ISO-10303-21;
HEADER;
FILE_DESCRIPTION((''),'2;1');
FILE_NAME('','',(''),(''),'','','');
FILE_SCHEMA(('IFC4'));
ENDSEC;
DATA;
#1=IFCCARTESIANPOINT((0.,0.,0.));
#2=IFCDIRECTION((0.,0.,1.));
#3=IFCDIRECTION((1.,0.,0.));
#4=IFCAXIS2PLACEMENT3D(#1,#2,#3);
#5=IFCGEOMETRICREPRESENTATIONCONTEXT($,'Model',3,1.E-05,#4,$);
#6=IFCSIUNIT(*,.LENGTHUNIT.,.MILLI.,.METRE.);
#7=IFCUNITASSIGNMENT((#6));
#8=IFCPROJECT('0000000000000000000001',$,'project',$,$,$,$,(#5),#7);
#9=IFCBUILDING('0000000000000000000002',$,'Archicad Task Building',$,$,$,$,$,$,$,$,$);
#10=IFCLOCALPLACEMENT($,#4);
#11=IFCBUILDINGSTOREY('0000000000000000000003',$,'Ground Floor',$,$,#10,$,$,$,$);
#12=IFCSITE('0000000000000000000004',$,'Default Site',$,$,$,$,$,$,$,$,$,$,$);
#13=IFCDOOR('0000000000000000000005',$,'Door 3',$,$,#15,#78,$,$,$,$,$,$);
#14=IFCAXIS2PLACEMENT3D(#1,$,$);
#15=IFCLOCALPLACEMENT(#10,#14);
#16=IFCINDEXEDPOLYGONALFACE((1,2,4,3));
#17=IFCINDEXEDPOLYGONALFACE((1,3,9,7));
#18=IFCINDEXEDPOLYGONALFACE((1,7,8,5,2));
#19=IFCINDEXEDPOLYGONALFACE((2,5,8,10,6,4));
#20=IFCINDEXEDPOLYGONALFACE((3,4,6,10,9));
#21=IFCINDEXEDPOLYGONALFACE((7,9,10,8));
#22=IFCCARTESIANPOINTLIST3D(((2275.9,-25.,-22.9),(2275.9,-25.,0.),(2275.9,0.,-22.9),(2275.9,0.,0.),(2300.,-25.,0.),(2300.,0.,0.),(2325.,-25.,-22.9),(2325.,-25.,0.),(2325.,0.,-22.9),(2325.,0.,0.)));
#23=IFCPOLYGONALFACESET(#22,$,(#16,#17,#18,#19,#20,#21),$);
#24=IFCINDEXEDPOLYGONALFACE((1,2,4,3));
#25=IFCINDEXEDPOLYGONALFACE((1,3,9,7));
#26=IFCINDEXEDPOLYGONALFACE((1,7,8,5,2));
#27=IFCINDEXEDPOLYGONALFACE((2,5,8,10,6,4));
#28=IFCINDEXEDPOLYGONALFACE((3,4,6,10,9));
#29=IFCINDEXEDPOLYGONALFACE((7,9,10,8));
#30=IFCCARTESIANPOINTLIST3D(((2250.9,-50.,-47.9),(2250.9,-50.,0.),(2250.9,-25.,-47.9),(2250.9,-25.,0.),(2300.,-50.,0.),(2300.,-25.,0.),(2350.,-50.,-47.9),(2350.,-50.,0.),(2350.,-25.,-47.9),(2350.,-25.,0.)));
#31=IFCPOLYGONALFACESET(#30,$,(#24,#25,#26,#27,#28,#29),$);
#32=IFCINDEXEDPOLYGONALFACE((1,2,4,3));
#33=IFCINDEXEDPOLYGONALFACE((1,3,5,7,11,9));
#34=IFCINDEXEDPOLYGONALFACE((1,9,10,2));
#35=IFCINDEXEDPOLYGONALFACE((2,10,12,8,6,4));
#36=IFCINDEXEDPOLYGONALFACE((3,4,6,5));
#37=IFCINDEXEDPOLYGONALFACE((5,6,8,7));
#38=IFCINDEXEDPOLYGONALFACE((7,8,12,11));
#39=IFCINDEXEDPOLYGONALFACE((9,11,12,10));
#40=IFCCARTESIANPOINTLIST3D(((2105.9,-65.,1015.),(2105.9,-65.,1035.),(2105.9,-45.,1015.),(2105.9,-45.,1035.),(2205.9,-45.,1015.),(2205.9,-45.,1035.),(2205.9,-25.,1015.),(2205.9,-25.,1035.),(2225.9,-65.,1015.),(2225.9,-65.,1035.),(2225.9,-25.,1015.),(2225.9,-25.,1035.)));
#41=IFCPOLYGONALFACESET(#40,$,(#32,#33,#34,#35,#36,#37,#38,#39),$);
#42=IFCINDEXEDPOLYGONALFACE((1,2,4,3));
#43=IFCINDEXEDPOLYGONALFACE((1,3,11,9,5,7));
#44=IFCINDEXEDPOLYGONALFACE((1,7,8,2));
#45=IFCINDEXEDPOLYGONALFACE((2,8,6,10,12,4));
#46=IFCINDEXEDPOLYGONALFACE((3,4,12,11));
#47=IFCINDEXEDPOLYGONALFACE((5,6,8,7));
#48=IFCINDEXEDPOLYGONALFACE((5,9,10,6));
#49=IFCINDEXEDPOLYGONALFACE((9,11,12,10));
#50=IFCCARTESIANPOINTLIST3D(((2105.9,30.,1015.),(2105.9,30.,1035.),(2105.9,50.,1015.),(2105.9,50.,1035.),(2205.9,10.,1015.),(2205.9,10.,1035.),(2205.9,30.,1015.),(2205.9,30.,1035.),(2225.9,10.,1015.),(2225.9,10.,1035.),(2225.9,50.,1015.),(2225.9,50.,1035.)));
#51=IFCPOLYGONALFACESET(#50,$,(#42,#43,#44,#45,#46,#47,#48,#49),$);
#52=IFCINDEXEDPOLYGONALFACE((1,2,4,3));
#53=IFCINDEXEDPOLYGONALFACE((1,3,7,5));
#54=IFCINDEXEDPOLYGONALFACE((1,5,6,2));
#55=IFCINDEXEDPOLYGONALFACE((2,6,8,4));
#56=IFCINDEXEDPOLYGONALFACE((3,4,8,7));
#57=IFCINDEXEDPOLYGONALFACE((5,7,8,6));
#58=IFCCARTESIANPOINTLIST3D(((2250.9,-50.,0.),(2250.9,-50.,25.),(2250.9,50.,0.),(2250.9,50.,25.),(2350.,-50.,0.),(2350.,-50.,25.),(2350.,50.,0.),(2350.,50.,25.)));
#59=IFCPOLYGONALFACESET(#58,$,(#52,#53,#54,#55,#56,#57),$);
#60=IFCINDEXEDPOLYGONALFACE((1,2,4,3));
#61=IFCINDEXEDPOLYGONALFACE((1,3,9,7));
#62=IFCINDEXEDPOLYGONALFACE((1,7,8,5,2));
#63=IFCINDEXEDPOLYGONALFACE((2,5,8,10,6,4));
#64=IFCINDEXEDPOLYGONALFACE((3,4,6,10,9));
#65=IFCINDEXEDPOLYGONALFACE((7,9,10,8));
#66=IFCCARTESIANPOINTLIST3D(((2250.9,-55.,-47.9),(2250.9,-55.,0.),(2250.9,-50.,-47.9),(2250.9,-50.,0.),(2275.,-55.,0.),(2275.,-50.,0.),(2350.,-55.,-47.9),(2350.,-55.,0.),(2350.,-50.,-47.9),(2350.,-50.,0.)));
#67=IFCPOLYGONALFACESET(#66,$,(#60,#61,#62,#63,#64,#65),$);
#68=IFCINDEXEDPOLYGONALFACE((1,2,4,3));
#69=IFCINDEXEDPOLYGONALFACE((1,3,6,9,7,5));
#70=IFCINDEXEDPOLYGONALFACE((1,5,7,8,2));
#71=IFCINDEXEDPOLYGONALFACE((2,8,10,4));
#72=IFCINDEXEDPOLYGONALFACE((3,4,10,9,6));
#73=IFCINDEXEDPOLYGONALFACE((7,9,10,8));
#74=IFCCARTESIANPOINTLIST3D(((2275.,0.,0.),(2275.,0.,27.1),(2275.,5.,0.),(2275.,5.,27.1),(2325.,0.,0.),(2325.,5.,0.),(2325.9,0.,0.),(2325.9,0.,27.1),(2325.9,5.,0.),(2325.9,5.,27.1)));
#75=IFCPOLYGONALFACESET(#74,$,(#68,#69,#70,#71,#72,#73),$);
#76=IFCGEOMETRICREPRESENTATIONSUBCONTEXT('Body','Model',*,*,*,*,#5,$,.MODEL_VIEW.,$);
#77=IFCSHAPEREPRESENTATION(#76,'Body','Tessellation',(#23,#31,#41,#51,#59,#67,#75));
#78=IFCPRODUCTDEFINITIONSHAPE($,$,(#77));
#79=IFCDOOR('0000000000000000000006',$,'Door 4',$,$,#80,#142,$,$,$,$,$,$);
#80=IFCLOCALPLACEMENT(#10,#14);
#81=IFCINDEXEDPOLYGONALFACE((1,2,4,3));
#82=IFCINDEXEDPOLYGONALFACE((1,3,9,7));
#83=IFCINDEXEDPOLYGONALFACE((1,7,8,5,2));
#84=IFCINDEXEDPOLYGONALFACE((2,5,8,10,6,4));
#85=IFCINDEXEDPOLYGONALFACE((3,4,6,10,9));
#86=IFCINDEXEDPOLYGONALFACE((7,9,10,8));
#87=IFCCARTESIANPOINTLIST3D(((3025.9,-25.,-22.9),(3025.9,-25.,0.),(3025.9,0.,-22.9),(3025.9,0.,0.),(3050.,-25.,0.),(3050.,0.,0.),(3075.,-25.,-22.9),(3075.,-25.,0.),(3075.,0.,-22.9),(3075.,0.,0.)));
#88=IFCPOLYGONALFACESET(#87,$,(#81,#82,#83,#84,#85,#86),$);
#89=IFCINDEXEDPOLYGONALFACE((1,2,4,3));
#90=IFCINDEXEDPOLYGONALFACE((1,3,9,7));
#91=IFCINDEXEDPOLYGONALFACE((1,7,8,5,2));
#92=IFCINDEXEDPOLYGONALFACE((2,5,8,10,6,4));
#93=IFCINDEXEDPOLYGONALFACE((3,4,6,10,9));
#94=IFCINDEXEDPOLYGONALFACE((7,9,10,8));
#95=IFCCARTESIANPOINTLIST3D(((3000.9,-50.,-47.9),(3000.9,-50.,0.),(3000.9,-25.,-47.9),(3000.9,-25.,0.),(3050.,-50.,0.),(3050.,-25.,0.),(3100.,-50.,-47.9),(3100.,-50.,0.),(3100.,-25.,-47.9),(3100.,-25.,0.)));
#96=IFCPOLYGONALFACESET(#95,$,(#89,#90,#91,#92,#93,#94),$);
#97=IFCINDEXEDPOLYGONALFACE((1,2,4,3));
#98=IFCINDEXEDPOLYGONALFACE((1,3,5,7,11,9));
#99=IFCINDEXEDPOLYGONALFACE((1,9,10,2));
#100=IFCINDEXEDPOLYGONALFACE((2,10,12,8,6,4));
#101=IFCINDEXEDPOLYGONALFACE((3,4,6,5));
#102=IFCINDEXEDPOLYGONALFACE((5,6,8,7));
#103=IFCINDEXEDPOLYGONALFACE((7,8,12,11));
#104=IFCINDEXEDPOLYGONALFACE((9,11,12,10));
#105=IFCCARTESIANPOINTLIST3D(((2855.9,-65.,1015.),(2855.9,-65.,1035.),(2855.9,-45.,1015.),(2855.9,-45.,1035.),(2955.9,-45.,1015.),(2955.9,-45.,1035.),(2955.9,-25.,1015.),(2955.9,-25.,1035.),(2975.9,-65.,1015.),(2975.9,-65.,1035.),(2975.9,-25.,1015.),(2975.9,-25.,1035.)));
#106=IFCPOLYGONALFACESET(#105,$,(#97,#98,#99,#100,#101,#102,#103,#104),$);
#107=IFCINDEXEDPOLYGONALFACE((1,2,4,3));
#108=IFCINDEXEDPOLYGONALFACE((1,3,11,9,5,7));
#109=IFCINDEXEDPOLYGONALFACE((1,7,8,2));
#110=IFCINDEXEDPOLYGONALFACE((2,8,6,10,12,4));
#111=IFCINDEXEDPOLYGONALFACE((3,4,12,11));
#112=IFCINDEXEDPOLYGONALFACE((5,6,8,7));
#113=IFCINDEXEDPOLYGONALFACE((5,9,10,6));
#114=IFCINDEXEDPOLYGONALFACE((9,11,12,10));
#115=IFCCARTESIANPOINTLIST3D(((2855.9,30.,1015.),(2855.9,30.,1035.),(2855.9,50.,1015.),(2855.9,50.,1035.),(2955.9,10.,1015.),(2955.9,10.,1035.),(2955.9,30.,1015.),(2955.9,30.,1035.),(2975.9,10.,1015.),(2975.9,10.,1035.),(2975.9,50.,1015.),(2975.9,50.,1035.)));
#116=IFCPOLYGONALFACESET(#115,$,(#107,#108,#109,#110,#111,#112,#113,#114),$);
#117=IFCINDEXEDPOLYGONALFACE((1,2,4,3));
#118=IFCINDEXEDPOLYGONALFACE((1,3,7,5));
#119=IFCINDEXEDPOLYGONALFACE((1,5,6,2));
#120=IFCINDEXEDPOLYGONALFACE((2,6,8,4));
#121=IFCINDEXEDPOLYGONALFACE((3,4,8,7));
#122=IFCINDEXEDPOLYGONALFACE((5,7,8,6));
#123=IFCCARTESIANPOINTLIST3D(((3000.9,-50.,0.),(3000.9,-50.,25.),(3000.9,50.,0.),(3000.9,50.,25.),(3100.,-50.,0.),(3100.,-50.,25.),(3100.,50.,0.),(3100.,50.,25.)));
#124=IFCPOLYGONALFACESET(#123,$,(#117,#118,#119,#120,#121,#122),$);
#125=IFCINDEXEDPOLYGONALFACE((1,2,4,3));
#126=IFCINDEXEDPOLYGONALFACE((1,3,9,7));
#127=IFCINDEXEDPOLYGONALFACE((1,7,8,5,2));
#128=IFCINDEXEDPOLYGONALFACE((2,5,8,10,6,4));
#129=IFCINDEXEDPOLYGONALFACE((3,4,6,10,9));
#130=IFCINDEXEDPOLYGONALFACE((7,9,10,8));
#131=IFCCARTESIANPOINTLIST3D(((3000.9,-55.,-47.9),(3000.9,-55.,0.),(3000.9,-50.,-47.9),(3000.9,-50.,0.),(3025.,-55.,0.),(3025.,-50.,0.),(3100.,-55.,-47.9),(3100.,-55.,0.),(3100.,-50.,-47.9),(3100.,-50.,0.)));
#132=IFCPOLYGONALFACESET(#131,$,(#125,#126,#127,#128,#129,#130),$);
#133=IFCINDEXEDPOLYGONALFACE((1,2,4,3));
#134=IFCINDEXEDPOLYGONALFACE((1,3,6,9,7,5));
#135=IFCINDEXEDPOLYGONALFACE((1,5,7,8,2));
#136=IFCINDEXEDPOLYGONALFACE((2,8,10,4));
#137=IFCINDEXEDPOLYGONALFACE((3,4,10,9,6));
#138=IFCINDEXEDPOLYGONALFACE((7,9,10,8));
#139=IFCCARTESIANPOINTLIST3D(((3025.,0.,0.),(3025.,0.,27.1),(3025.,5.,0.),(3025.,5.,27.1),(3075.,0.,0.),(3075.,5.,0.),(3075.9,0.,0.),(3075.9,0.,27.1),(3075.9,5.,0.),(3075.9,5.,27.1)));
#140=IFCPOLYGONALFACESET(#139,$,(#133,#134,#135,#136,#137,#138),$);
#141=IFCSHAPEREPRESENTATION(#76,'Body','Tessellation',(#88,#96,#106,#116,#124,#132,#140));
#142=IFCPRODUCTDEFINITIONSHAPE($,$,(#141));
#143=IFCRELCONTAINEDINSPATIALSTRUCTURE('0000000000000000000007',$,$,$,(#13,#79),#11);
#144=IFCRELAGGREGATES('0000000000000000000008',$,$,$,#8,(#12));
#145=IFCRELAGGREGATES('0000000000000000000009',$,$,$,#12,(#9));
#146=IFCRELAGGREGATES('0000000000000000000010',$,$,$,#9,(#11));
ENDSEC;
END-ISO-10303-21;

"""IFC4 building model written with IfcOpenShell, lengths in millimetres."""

from ifc_helpers import new_model, si_unit, frame, origin_with_axes, place, context, subcontext, project, spatial, line, indexed_curve, outline, extrude, element, save


model = new_model("IFC4")

# Units and contexts
model_context = context("Model", 3, precision=1e-05, world=origin_with_axes())
body_context = subcontext(model_context, "Body", "Model", "MODEL_VIEW")
ifc_project = project(units=[si_unit("LENGTHUNIT", "METRE", prefix="MILLI")], contexts=[model_context])

# Site, building, storey
site = spatial("IfcSite", under=ifc_project, Name="Default Site")
building = spatial("IfcBuilding", under=site, Name="Archicad Task Building")
storey_placement = place(None, origin_with_axes())
storey = spatial("IfcBuildingStorey", under=building, at=storey_placement, Name="Ground Floor")

# Doors
door_1_placement = place(storey_placement, frame((2300.0, -50.0, 0.0), z_axis=(0.0, 0.0, 1.0), x_axis=(1.0, 0.0, 0.0)))
element("IfcDoor", 1, at=door_1_placement, inside=storey, Name="Door 3", context=body_context, shape_type="SweptSolid", body=[
    extrude(outline(indexed_curve([(0.0, 0.0), (0.0, 2.1), (0.9, 2.1), (0.9, 0.0), (-24.1, 0.0), (-24.1, -22.9), (25.0, -22.9), (25.0, 0.0)], segments=[line(1, 2, 3, 4, 5, 6, 7, 8, 1)])), frame((0.0, 25.0, 0.0), z_axis=(0.0, -1.0, 0.0), x_axis=(1.0, 0.0, 0.0)), (0.0, 0.0, -1.0), 25.0),
    extrude(outline(indexed_curve([(0.0, 0.0), (0.0, 2.1), (0.9, 2.1), (0.9, 0.0), (-49.1, 0.0), (-49.1, -47.9), (50.0, -47.9), (50.0, 0.0)], segments=[line(1, 2, 3, 4, 5, 6, 7, 8, 1)])), frame((0.0, 0.0, 0.0), z_axis=(0.0, -1.0, 0.0), x_axis=(1.0, 0.0, 0.0)), (0.0, 0.0, -1.0), 25.0),
    extrude(outline(indexed_curve([(0.0, 0.0), (-49.1, 0.0), (-49.1, 35.0), (0.0, 35.0)], segments=[line(1, 2, 3, 4, 1)])), frame((25.0, 25.0, 25.0), z_axis=(0.0, 0.0, 1.0), x_axis=(1.0, 0.0, 0.0)), (0.0, 0.0, 1.0), -47.9),
    extrude(outline(indexed_curve([(0.0, 0.0), (0.0, -40.0), (-120.0, -40.0), (-120.0, -20.0), (-20.0, -20.0), (-20.0, 0.0)], segments=[line(1, 2, 3, 4, 5, 6, 1)])), frame((-74.1, 25.0, 1015.0), z_axis=(0.0, 0.0, 1.0), x_axis=(1.0, 0.0, 0.0)), (0.0, 0.0, 1.0), 20.0),
    extrude(outline(indexed_curve([(0.0, 0.0), (0.0, 40.0), (-120.0, 40.0), (-120.0, 20.0), (-20.0, 20.0), (-20.0, 0.0)], segments=[line(1, 2, 3, 4, 5, 6, 1)])), frame((-74.1, 60.0, 1015.0), z_axis=(0.0, 0.0, 1.0), x_axis=(1.0, 0.0, 0.0)), (0.0, 0.0, 1.0), 20.0),
    extrude(outline(indexed_curve([(0.0, 0.0), (-99.1, 0.0), (-99.1, 100.0), (0.0, 100.0)], segments=[line(1, 2, 3, 4, 1)])), frame((50.0, 0.0, 0.0), z_axis=(0.0, 0.0, 1.0), x_axis=(1.0, 0.0, 0.0)), (0.0, 0.0, 1.0), 25.0),
    extrude(outline(indexed_curve([(0.0, 0.0), (0.0, 27.1), (50.9, 27.1), (50.9, 0.0), (-24.1, 0.0), (-24.1, -47.9), (75.0, -47.9), (75.0, 0.0)], segments=[line(1, 2, 3, 4, 5, 6, 7, 8, 1)])), frame((-25.0, -5.0, 0.0), z_axis=(0.0, -1.0, 0.0), x_axis=(1.0, 0.0, 0.0)), (0.0, 0.0, -1.0), 5.0),
    extrude(outline(indexed_curve([(0.0, 0.0), (0.0, 27.1), (50.9, 27.1), (50.9, 0.0), (0.9, 0.0), (0.9, -22.9), (50.0, -22.9), (50.0, 0.0)], segments=[line(1, 2, 3, 4, 5, 6, 7, 8, 1)])), frame((-25.0, 50.0, 0.0), z_axis=(0.0, -1.0, 0.0), x_axis=(1.0, 0.0, 0.0)), (0.0, 0.0, -1.0), 5.0),
])
door_2_placement = place(storey_placement, frame((3050.0, -50.0, 0.0), z_axis=(0.0, 0.0, 1.0), x_axis=(1.0, 0.0, 0.0)))
element("IfcDoor", 2, at=door_2_placement, inside=storey, Name="Door 4", context=body_context, shape_type="SweptSolid", body=[
    extrude(outline(indexed_curve([(0.0, 0.0), (0.0, 2.1), (0.9, 2.1), (0.9, 0.0), (-24.1, 0.0), (-24.1, -22.9), (25.0, -22.9), (25.0, 0.0)], segments=[line(1, 2, 3, 4, 5, 6, 7, 8, 1)])), frame((0.0, 25.0, 0.0), z_axis=(0.0, -1.0, 0.0), x_axis=(1.0, 0.0, 0.0)), (0.0, 0.0, -1.0), 25.0),
    extrude(outline(indexed_curve([(0.0, 0.0), (0.0, 2.1), (0.9, 2.1), (0.9, 0.0), (-49.1, 0.0), (-49.1, -47.9), (50.0, -47.9), (50.0, 0.0)], segments=[line(1, 2, 3, 4, 5, 6, 7, 8, 1)])), frame((0.0, 0.0, 0.0), z_axis=(0.0, -1.0, 0.0), x_axis=(1.0, 0.0, 0.0)), (0.0, 0.0, -1.0), 25.0),
    extrude(outline(indexed_curve([(0.0, 0.0), (-49.1, 0.0), (-49.1, 35.0), (0.0, 35.0)], segments=[line(1, 2, 3, 4, 1)])), frame((25.0, 25.0, 25.0), z_axis=(0.0, 0.0, 1.0), x_axis=(1.0, 0.0, 0.0)), (0.0, 0.0, 1.0), -47.9),
    extrude(outline(indexed_curve([(0.0, 0.0), (0.0, -40.0), (-120.0, -40.0), (-120.0, -20.0), (-20.0, -20.0), (-20.0, 0.0)], segments=[line(1, 2, 3, 4, 5, 6, 1)])), frame((-74.1, 25.0, 1015.0), z_axis=(0.0, 0.0, 1.0), x_axis=(1.0, 0.0, 0.0)), (0.0, 0.0, 1.0), 20.0),
    extrude(outline(indexed_curve([(0.0, 0.0), (0.0, 40.0), (-120.0, 40.0), (-120.0, 20.0), (-20.0, 20.0), (-20.0, 0.0)], segments=[line(1, 2, 3, 4, 5, 6, 1)])), frame((-74.1, 60.0, 1015.0), z_axis=(0.0, 0.0, 1.0), x_axis=(1.0, 0.0, 0.0)), (0.0, 0.0, 1.0), 20.0),
    extrude(outline(indexed_curve([(0.0, 0.0), (-99.1, 0.0), (-99.1, 100.0), (0.0, 100.0)], segments=[line(1, 2, 3, 4, 1)])), frame((50.0, 0.0, 0.0), z_axis=(0.0, 0.0, 1.0), x_axis=(1.0, 0.0, 0.0)), (0.0, 0.0, 1.0), 25.0),
    extrude(outline(indexed_curve([(0.0, 0.0), (0.0, 27.1), (50.9, 27.1), (50.9, 0.0), (-24.1, 0.0), (-24.1, -47.9), (75.0, -47.9), (75.0, 0.0)], segments=[line(1, 2, 3, 4, 5, 6, 7, 8, 1)])), frame((-25.0, -5.0, 0.0), z_axis=(0.0, -1.0, 0.0), x_axis=(1.0, 0.0, 0.0)), (0.0, 0.0, -1.0), 5.0),
    extrude(outline(indexed_curve([(0.0, 0.0), (0.0, 27.1), (50.9, 27.1), (50.9, 0.0), (0.9, 0.0), (0.9, -22.9), (50.0, -22.9), (50.0, 0.0)], segments=[line(1, 2, 3, 4, 5, 6, 7, 8, 1)])), frame((-25.0, 50.0, 0.0), z_axis=(0.0, -1.0, 0.0), x_axis=(1.0, 0.0, 0.0)), (0.0, 0.0, -1.0), 5.0),
])

save(model, "model.ifc")
